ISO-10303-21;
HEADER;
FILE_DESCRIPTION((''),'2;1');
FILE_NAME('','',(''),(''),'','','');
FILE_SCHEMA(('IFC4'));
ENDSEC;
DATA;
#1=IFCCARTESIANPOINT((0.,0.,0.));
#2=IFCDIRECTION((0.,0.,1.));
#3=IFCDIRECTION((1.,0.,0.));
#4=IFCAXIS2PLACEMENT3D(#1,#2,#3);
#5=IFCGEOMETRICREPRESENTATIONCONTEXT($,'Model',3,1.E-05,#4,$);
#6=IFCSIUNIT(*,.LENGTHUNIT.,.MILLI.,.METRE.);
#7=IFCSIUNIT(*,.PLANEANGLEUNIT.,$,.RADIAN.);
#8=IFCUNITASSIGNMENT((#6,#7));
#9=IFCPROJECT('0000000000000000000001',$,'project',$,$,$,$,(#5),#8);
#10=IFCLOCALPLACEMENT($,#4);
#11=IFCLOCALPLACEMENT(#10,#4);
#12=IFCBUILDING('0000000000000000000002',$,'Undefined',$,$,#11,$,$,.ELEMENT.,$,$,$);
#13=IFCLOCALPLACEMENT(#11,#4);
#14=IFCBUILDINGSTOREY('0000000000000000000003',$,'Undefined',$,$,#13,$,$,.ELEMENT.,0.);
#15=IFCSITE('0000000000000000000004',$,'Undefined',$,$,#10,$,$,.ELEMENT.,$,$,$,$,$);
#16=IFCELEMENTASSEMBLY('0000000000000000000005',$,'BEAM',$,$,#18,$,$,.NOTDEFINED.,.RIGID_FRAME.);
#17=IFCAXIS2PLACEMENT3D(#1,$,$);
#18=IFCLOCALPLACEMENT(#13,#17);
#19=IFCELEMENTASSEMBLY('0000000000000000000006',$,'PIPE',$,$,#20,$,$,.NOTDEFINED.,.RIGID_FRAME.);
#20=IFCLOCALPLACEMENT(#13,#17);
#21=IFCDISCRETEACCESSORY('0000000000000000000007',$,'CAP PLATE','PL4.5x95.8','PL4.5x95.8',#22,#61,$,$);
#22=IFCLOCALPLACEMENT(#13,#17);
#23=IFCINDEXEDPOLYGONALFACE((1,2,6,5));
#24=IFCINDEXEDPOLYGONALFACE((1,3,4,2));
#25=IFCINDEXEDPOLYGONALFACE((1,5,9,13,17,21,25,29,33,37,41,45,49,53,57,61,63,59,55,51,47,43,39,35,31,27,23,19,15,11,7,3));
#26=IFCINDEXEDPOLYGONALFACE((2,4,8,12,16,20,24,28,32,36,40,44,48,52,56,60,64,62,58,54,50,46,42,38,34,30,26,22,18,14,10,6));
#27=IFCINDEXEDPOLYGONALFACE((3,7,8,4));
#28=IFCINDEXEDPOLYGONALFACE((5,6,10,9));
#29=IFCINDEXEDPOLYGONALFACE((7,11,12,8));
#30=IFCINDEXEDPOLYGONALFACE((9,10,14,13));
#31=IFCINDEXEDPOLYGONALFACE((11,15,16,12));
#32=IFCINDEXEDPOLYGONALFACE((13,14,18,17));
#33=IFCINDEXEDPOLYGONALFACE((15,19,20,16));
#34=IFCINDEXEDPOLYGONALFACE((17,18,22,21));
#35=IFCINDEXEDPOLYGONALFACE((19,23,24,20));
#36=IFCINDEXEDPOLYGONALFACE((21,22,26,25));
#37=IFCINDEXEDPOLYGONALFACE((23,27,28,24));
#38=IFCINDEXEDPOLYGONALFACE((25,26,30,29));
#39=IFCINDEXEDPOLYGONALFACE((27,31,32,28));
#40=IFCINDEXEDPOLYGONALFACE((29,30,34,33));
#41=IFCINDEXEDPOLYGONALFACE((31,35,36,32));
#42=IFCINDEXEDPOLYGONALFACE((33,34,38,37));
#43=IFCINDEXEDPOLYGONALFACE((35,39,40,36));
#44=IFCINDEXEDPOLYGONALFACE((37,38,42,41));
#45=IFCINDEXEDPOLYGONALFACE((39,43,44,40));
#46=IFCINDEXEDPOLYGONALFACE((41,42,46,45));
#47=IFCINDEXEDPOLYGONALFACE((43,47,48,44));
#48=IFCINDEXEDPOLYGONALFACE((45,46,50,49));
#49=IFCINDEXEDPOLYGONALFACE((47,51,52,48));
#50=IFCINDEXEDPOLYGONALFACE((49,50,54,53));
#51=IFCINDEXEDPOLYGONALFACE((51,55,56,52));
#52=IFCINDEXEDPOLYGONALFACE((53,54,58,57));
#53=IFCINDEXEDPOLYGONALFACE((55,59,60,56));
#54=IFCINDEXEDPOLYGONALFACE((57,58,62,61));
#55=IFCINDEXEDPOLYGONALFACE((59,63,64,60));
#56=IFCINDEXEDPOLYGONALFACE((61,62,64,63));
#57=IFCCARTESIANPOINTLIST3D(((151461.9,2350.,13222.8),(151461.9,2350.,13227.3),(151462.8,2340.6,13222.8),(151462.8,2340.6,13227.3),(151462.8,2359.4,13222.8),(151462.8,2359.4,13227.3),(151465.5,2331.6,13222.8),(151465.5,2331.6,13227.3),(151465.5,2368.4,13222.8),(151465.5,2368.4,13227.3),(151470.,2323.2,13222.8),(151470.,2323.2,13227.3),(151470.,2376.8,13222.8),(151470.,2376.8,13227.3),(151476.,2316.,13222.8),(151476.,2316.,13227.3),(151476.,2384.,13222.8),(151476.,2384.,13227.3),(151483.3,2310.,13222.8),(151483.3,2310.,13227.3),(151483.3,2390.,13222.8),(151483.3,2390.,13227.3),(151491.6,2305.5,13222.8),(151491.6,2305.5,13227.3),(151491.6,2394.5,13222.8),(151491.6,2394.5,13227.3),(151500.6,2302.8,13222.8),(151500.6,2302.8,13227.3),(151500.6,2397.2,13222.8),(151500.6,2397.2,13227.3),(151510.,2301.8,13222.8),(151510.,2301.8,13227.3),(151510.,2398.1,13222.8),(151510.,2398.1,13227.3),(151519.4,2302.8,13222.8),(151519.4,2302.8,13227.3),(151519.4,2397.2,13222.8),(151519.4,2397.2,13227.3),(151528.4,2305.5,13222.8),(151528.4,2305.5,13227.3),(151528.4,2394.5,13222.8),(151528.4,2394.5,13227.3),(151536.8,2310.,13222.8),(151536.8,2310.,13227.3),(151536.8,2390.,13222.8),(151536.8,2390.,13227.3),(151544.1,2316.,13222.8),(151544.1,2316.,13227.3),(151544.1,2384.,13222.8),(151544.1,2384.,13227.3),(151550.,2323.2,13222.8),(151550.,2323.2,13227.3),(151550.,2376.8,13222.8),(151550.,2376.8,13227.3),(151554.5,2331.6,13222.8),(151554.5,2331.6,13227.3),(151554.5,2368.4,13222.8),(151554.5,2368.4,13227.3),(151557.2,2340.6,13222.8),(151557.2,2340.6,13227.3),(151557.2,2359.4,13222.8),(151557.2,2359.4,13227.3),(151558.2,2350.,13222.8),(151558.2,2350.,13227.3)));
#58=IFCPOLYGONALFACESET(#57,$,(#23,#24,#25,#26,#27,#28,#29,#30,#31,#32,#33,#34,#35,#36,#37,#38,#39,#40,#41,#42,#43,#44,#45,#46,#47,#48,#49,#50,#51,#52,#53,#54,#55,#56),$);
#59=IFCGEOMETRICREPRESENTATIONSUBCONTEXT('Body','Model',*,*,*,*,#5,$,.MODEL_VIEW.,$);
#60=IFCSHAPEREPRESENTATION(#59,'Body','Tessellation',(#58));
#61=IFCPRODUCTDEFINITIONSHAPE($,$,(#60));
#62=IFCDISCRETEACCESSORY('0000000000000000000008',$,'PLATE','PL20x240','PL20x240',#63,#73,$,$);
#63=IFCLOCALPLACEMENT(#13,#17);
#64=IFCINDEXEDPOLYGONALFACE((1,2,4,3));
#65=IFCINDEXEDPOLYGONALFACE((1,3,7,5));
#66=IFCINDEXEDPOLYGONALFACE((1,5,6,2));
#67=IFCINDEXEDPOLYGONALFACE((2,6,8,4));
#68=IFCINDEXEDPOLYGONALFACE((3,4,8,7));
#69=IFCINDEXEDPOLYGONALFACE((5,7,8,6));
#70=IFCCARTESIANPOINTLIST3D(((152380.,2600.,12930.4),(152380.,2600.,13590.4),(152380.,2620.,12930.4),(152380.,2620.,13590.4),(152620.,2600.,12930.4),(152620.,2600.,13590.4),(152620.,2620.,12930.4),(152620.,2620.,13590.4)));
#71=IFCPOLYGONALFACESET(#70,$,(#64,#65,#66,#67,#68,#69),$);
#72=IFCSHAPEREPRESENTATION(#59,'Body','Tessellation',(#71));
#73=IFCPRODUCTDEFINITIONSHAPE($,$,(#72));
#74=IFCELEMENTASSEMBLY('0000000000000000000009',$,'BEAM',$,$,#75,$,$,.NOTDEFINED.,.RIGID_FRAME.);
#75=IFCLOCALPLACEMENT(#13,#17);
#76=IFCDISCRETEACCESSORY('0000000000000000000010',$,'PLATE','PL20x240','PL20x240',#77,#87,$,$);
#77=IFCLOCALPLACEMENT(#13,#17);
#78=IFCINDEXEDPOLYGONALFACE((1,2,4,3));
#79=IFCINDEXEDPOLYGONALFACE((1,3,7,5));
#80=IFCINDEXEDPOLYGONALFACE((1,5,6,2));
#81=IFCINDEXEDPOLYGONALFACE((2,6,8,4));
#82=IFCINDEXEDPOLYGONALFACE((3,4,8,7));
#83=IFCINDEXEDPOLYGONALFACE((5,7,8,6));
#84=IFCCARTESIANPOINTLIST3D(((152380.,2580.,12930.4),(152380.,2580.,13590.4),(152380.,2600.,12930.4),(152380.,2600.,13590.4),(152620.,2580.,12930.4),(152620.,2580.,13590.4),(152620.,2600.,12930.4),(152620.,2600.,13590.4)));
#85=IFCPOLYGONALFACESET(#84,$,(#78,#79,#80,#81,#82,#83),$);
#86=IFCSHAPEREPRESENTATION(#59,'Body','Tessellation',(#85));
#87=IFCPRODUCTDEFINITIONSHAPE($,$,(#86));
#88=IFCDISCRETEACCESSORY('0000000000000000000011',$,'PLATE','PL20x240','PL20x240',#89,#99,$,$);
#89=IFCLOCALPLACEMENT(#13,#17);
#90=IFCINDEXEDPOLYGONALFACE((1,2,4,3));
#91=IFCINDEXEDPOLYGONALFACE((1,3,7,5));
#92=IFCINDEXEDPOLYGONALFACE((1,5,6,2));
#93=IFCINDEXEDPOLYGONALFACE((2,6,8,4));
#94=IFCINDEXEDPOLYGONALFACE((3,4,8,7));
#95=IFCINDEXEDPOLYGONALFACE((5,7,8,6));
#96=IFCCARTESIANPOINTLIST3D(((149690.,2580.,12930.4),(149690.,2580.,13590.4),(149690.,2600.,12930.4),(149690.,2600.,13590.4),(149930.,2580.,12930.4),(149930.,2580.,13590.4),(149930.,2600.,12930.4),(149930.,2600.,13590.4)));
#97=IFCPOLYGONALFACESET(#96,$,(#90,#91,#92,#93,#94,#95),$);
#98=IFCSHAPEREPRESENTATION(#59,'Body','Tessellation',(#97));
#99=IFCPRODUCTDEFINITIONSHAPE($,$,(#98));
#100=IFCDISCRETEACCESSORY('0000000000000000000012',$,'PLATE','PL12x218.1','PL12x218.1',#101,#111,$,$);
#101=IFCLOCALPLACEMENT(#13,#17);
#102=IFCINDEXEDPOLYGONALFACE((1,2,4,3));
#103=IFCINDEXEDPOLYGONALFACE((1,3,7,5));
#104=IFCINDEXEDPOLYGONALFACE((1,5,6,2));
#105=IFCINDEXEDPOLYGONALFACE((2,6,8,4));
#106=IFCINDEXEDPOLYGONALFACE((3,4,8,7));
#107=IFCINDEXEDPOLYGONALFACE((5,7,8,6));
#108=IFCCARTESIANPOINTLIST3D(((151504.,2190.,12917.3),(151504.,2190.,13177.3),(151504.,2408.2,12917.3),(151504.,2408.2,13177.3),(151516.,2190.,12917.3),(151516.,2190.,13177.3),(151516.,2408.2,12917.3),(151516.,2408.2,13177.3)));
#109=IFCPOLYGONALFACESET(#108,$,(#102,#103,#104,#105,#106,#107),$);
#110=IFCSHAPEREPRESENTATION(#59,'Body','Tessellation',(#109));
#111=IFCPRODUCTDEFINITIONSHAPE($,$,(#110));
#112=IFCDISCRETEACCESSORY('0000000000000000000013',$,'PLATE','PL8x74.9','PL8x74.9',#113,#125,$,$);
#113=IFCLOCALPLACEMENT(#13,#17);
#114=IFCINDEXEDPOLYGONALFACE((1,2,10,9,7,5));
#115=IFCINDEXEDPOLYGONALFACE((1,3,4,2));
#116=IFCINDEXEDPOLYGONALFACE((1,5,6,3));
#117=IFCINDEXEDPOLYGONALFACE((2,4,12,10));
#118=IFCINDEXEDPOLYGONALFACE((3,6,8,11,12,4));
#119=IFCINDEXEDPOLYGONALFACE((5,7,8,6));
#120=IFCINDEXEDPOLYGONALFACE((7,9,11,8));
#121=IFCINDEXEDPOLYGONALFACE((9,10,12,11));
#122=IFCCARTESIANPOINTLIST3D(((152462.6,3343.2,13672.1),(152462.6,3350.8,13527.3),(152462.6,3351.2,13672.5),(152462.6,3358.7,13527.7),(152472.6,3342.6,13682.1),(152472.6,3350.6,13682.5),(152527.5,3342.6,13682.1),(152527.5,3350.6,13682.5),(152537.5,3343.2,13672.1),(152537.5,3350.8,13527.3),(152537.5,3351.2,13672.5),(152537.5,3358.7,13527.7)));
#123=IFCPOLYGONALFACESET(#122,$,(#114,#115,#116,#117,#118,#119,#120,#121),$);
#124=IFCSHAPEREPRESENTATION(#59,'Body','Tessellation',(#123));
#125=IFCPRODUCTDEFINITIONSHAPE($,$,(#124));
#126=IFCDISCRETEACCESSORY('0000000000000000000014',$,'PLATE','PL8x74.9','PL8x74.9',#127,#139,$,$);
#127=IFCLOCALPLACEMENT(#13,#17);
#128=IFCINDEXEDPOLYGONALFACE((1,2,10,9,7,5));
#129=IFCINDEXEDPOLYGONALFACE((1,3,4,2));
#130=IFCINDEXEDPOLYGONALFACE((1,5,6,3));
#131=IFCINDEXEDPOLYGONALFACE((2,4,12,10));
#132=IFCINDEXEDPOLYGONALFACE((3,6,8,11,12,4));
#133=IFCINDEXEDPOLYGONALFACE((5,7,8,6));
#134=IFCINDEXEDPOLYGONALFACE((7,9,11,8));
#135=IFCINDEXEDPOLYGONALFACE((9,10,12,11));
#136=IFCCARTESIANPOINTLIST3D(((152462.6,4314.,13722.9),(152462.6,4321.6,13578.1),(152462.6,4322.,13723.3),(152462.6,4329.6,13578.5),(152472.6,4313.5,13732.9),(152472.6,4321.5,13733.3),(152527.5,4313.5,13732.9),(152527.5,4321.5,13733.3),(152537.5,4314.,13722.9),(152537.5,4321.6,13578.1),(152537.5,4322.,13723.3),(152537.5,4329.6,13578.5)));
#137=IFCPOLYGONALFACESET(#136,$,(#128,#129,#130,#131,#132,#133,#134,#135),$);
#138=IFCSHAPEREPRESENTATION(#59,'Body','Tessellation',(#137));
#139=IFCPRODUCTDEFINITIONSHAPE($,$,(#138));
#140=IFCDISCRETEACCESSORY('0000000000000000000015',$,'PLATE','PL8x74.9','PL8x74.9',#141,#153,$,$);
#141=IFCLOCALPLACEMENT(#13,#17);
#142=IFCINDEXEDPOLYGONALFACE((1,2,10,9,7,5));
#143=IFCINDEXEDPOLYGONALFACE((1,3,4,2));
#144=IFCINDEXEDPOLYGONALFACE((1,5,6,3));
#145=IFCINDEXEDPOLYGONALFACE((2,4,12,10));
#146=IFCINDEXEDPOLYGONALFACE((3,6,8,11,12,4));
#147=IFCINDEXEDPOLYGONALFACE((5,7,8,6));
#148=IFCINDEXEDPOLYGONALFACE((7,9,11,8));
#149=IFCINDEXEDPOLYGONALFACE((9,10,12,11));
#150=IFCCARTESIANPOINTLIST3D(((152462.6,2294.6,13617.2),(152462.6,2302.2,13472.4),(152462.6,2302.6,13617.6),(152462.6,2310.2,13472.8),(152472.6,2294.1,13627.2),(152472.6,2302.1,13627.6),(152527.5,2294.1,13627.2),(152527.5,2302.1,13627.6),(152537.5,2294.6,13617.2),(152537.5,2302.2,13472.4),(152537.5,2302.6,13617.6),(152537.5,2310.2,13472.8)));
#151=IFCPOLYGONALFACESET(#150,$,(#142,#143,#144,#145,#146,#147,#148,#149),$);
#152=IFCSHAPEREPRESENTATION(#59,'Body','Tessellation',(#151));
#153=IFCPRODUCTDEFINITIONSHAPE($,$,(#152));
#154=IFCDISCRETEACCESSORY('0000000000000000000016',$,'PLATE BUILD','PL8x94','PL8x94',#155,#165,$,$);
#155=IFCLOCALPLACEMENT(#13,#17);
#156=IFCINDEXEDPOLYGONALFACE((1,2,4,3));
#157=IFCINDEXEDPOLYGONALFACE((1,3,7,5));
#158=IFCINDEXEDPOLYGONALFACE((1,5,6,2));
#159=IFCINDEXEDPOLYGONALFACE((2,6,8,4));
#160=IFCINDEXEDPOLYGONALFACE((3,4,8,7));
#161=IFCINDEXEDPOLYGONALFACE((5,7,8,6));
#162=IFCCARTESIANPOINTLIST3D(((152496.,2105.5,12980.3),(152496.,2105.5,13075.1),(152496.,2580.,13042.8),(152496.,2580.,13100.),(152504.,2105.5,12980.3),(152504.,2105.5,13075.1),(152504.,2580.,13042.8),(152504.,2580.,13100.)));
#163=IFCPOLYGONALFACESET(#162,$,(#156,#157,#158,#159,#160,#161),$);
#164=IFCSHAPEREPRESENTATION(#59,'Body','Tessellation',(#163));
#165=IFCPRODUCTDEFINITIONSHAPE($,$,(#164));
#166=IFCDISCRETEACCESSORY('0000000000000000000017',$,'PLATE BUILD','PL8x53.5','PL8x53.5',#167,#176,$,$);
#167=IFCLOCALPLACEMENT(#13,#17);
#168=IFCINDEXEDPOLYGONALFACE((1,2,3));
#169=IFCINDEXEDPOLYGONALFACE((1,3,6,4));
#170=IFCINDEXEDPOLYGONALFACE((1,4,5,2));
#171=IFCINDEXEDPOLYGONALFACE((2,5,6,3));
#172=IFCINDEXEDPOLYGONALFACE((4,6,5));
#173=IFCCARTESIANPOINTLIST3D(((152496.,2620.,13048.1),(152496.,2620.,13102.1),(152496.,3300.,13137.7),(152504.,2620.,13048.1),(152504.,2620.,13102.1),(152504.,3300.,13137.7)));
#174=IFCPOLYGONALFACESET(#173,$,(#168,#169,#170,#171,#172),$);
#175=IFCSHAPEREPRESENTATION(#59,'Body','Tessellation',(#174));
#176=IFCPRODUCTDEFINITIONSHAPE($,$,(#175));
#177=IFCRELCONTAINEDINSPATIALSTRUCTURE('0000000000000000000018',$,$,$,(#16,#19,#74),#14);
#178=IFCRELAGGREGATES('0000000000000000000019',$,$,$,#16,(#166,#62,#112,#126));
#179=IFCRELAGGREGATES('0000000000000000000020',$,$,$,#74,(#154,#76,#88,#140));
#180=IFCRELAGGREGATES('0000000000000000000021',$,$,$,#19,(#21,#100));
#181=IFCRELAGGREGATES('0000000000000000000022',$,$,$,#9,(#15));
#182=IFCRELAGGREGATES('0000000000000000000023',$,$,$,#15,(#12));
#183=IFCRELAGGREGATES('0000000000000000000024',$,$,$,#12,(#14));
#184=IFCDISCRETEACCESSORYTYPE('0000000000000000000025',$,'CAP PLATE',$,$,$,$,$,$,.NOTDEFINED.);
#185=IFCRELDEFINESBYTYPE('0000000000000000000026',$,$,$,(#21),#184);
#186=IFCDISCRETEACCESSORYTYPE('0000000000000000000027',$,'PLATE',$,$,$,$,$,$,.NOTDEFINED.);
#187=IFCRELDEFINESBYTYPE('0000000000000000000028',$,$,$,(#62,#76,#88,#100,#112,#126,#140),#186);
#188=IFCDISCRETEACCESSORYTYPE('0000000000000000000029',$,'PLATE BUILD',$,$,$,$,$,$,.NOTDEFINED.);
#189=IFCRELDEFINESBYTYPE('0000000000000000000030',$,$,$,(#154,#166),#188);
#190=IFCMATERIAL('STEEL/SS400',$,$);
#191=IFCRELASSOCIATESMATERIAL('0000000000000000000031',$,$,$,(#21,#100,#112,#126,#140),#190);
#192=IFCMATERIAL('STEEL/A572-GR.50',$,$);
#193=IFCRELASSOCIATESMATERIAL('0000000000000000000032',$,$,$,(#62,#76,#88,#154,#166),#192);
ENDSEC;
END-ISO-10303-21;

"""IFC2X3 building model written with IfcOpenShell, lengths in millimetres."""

from ifc_helpers import new_model, si_unit, frame, origin_with_axes, origin_2d_with_axis, place, context, subcontext, project, spatial, polyline, rectangle, outline, extrude, material, type_object, element, aggregate, save


model = new_model("IFC2X3")

# Units and contexts
model_context = context("Model", 3, precision=1e-05, world=origin_with_axes())
body_context = subcontext(model_context, "Body", "Model", "MODEL_VIEW")
ifc_project = project(units=[si_unit("LENGTHUNIT", "METRE", prefix="MILLI"), si_unit("PLANEANGLEUNIT", "RADIAN")], contexts=[model_context])

# Site, building, storey
site_placement = place(None, origin_with_axes())
site = spatial("IfcSite", under=ifc_project, at=site_placement, Name="Undefined", CompositionType="ELEMENT")
building_placement = place(site_placement, origin_with_axes())
building = spatial("IfcBuilding", under=site, at=building_placement, Name="Undefined", CompositionType="ELEMENT")
storey_placement = place(building_placement, origin_with_axes())
storey = spatial("IfcBuildingStorey", under=building, at=storey_placement, Name="Undefined", CompositionType="ELEMENT", Elevation=0.0)

# Element assembly
assembly_1_placement = place(storey_placement, origin_with_axes())
assembly_1 = element("IfcElementAssembly", 1, at=assembly_1_placement, inside=storey, Name="BEAM", AssemblyPlace="NOTDEFINED", PredefinedType="RIGID_FRAME")

# Element assembly, discrete accessory
assembly_2_placement = place(storey_placement, origin_with_axes())
assembly_2 = element("IfcElementAssembly", 2, at=assembly_2_placement, inside=storey, Name="PIPE", AssemblyPlace="NOTDEFINED", PredefinedType="RIGID_FRAME")
ifc_material_1 = material(Name="STEEL/SS400")
discrete_accessory_type_1 = type_object("IfcDiscreteAccessoryType", Name="CAP PLATE")
discrete_accessory_1_placement = place(assembly_2_placement, frame((151519.4, 2302.8, 13225.1), z_axis=(0.0, 0.0, 1.0), x_axis=(0.95694, 0.290285, 0.0)))
discrete_accessory_1 = element("IfcDiscreteAccessory", 3, at=discrete_accessory_1_placement, type_object=discrete_accessory_type_1, material=ifc_material_1, Name="CAP PLATE", Description="PL4.5x95.8", ObjectType="PL4.5x95.8", context=body_context, shape_type="SweptSolid", body=[
    extrude(outline(polyline([(0.0, 0.0), (9.4, 0.0), (18.7, 1.8), (27.4, 5.5), (35.3, 10.7), (41.9, 17.4), (47.2, 25.2), (50.8, 33.9), (52.6, 43.2), (52.6, 52.6), (50.8, 61.9), (47.2, 70.6), (41.9, 78.5), (35.3, 85.1), (27.4, 90.4), (18.7, 94.0), (9.4, 95.8), (0.0, 95.8), (-9.3, 94.0), (-18.0, 90.4), (-25.8, 85.1), (-32.5, 78.5), (-37.7, 70.6), (-41.4, 61.9), (-43.2, 52.6), (-43.2, 43.2), (-41.4, 33.9), (-37.7, 25.2), (-32.5, 17.4), (-25.8, 10.7), (-18.0, 5.5), (-9.3, 1.8), (0.0, 0.0)])), frame((0.0, 0.0, -2.2), z_axis=(0.0, 0.0, 1.0), x_axis=(1.0, 0.0, 0.0)), (0.0, 0.0, 1.0), 4.5),
])

# Discrete accessory
ifc_material_2 = material(Name="STEEL/A572-GR.50")
discrete_accessory_type_2 = type_object("IfcDiscreteAccessoryType", Name="PLATE")
discrete_accessory_2_placement = place(assembly_1_placement, frame((152500.0, 2610.0, 13590.4), z_axis=(1.0, 0.0, 0.0), x_axis=(0.0, 0.0, -1.0)))
discrete_accessory_2 = element("IfcDiscreteAccessory", 4, at=discrete_accessory_2_placement, type_object=discrete_accessory_type_2, material=ifc_material_2, Name="PLATE", Description="PL20x240", ObjectType="PL20x240", context=body_context, shape_type="SweptSolid", body=[
    extrude(rectangle(XDim=20.0, YDim=240.0, at=origin_2d_with_axis()), frame((660.0, 0.0, 0.0), z_axis=(-1.0, 0.0, 0.0), x_axis=(0.0, -1.0, 0.0)), (0.0, 0.0, 1.0), 660.0),
])

# Element assembly, discrete accessories
assembly_3_placement = place(storey_placement, origin_with_axes())
assembly_3 = element("IfcElementAssembly", 5, at=assembly_3_placement, inside=storey, Name="BEAM", AssemblyPlace="NOTDEFINED", PredefinedType="RIGID_FRAME")
discrete_accessory_3_placement = place(assembly_3_placement, frame((152500.0, 2590.0, 13590.4), z_axis=(1.0, 0.0, 0.0), x_axis=(0.0, 0.0, -1.0)))
discrete_accessory_3 = element("IfcDiscreteAccessory", 6, at=discrete_accessory_3_placement, type_object=discrete_accessory_type_2, material=ifc_material_2, Name="PLATE", Description="PL20x240", ObjectType="PL20x240", context=body_context, shape_type="SweptSolid", body=[
    extrude(rectangle(XDim=20.0, YDim=240.0, at=origin_2d_with_axis()), frame((660.0, 0.0, 0.0), z_axis=(-1.0, 0.0, 0.0), x_axis=(0.0, -1.0, 0.0)), (0.0, 0.0, 1.0), 660.0),
])
discrete_accessory_4_placement = place(assembly_3_placement, frame((149810.0, 2590.0, 13590.4), z_axis=(1.0, 0.0, 0.0), x_axis=(0.0, 0.0, -1.0)))
discrete_accessory_4 = element("IfcDiscreteAccessory", 7, at=discrete_accessory_4_placement, type_object=discrete_accessory_type_2, material=ifc_material_2, Name="PLATE", Description="PL20x240", ObjectType="PL20x240", context=body_context, shape_type="SweptSolid", body=[
    extrude(rectangle(XDim=20.0, YDim=240.0, at=origin_2d_with_axis()), frame((660.0, 0.0, 0.0), z_axis=(-1.0, 0.0, 0.0), x_axis=(0.0, -1.0, 0.0)), (0.0, 0.0, 1.0), 660.0),
])

# Discrete accessories
discrete_accessory_5_placement = place(assembly_2_placement, frame((151510.0, 2190.0, 13177.3), z_axis=(-1.0, 0.0, 0.0), x_axis=(0.0, 1.0, 0.0)))
discrete_accessory_5 = element("IfcDiscreteAccessory", 8, at=discrete_accessory_5_placement, type_object=discrete_accessory_type_2, material=ifc_material_1, Name="PLATE", Description="PL12x218.1", ObjectType="PL12x218.1", context=body_context, shape_type="SweptSolid", body=[
    extrude(outline(polyline([(0.0, 0.0), (218.1, 0.0), (218.1, 260.0), (0.0, 260.0), (0.0, 0.0)])), frame((0.0, 0.0, -6.0), z_axis=(0.0, 0.0, 1.0), x_axis=(1.0, 0.0, 0.0)), (0.0, 0.0, 1.0), 12.0),
])
discrete_accessory_6_placement = place(assembly_1_placement, frame((152462.6, 3354.8, 13527.5), z_axis=(0.0, 0.998629, 0.052338), x_axis=(0.0, -0.052338, 0.998629)))
discrete_accessory_6 = element("IfcDiscreteAccessory", 9, at=discrete_accessory_6_placement, type_object=discrete_accessory_type_2, material=ifc_material_1, Name="PLATE", Description="PL8x74.9", ObjectType="PL8x74.9", context=body_context, shape_type="SweptSolid", body=[
    extrude(outline(polyline([(0.0, 0.0), (145.0, 0.0), (155.0, 10.0), (155.0, 64.9), (145.0, 74.9), (0.0, 74.9), (0.0, 0.0)])), frame((0.0, 0.0, -4.0), z_axis=(0.0, 0.0, 1.0), x_axis=(1.0, 0.0, 0.0)), (0.0, 0.0, 1.0), 8.0),
])
discrete_accessory_7_placement = place(assembly_1_placement, frame((152462.6, 4325.6, 13578.3), z_axis=(0.0, 0.998629, 0.052338), x_axis=(0.0, -0.052338, 0.998629)))
discrete_accessory_7 = element("IfcDiscreteAccessory", 10, at=discrete_accessory_7_placement, type_object=discrete_accessory_type_2, material=ifc_material_1, Name="PLATE", Description="PL8x74.9", ObjectType="PL8x74.9", context=body_context, shape_type="SweptSolid", body=[
    extrude(outline(polyline([(0.0, 0.0), (145.0, 0.0), (155.0, 10.0), (155.0, 64.9), (145.0, 74.9), (0.0, 74.9), (0.0, 0.0)])), frame((0.0, 0.0, -4.0), z_axis=(0.0, 0.0, 1.0), x_axis=(1.0, 0.0, 0.0)), (0.0, 0.0, 1.0), 8.0),
])
discrete_accessory_8_placement = place(assembly_3_placement, frame((152462.6, 2306.2, 13472.6), z_axis=(0.0, 0.998629, 0.052338), x_axis=(0.0, -0.052338, 0.998629)))
discrete_accessory_8 = element("IfcDiscreteAccessory", 11, at=discrete_accessory_8_placement, type_object=discrete_accessory_type_2, material=ifc_material_1, Name="PLATE", Description="PL8x74.9", ObjectType="PL8x74.9", context=body_context, shape_type="SweptSolid", body=[
    extrude(outline(polyline([(0.0, 0.0), (145.0, 0.0), (155.0, 10.0), (155.0, 64.9), (145.0, 74.9), (0.0, 74.9), (0.0, 0.0)])), frame((0.0, 0.0, -4.0), z_axis=(0.0, 0.0, 1.0), x_axis=(1.0, 0.0, 0.0)), (0.0, 0.0, 1.0), 8.0),
])

# Discrete accessories
discrete_accessory_type_3 = type_object("IfcDiscreteAccessoryType", Name="PLATE BUILD")
discrete_accessory_9_placement = place(assembly_3_placement, frame((152500.0, 2580.0, 13042.8), z_axis=(1.0, 0.0, 0.0), x_axis=(0.0, -0.000009, 1.0)))
discrete_accessory_9 = element("IfcDiscreteAccessory", 12, at=discrete_accessory_9_placement, type_object=discrete_accessory_type_3, material=ifc_material_2, Name="PLATE BUILD", Description="PL8x94", ObjectType="PL8x94", context=body_context, shape_type="SweptSolid", body=[
    extrude(outline(polyline([(0.0, 0.0), (57.2, 0.0), (32.3, 474.5), (-62.5, 474.5), (0.0, 0.0)])), frame((0.0, 0.0, -4.0), z_axis=(0.0, 0.0, 1.0), x_axis=(1.0, 0.0, 0.0)), (0.0, 0.0, 1.0), 8.0),
])
discrete_accessory_10_placement = place(assembly_1_placement, frame((152500.0, 3300.0, 13137.7), z_axis=(1.0, 0.0, 0.0), x_axis=(0.0, -0.99863, -0.052323)))
discrete_accessory_10 = element("IfcDiscreteAccessory", 13, at=discrete_accessory_10_placement, type_object=discrete_accessory_type_3, material=ifc_material_2, Name="PLATE BUILD", Description="PL8x53.5", ObjectType="PL8x53.5", context=body_context, shape_type="SweptSolid", body=[
    extrude(outline(polyline([(0.0, 0.0), (680.9, 0.0), (683.8, 53.9), (0.0, 0.0)])), frame((0.0, 0.0, -4.0), z_axis=(0.0, 0.0, 1.0), x_axis=(1.0, 0.0, 0.0)), (0.0, 0.0, 1.0), 8.0),
])
aggregate(assembly_1, [discrete_accessory_10, discrete_accessory_2, discrete_accessory_6, discrete_accessory_7])
aggregate(assembly_3, [discrete_accessory_9, discrete_accessory_3, discrete_accessory_4, discrete_accessory_8])

aggregate(assembly_2, [discrete_accessory_1, discrete_accessory_5])

save(model, "model.ifc")
